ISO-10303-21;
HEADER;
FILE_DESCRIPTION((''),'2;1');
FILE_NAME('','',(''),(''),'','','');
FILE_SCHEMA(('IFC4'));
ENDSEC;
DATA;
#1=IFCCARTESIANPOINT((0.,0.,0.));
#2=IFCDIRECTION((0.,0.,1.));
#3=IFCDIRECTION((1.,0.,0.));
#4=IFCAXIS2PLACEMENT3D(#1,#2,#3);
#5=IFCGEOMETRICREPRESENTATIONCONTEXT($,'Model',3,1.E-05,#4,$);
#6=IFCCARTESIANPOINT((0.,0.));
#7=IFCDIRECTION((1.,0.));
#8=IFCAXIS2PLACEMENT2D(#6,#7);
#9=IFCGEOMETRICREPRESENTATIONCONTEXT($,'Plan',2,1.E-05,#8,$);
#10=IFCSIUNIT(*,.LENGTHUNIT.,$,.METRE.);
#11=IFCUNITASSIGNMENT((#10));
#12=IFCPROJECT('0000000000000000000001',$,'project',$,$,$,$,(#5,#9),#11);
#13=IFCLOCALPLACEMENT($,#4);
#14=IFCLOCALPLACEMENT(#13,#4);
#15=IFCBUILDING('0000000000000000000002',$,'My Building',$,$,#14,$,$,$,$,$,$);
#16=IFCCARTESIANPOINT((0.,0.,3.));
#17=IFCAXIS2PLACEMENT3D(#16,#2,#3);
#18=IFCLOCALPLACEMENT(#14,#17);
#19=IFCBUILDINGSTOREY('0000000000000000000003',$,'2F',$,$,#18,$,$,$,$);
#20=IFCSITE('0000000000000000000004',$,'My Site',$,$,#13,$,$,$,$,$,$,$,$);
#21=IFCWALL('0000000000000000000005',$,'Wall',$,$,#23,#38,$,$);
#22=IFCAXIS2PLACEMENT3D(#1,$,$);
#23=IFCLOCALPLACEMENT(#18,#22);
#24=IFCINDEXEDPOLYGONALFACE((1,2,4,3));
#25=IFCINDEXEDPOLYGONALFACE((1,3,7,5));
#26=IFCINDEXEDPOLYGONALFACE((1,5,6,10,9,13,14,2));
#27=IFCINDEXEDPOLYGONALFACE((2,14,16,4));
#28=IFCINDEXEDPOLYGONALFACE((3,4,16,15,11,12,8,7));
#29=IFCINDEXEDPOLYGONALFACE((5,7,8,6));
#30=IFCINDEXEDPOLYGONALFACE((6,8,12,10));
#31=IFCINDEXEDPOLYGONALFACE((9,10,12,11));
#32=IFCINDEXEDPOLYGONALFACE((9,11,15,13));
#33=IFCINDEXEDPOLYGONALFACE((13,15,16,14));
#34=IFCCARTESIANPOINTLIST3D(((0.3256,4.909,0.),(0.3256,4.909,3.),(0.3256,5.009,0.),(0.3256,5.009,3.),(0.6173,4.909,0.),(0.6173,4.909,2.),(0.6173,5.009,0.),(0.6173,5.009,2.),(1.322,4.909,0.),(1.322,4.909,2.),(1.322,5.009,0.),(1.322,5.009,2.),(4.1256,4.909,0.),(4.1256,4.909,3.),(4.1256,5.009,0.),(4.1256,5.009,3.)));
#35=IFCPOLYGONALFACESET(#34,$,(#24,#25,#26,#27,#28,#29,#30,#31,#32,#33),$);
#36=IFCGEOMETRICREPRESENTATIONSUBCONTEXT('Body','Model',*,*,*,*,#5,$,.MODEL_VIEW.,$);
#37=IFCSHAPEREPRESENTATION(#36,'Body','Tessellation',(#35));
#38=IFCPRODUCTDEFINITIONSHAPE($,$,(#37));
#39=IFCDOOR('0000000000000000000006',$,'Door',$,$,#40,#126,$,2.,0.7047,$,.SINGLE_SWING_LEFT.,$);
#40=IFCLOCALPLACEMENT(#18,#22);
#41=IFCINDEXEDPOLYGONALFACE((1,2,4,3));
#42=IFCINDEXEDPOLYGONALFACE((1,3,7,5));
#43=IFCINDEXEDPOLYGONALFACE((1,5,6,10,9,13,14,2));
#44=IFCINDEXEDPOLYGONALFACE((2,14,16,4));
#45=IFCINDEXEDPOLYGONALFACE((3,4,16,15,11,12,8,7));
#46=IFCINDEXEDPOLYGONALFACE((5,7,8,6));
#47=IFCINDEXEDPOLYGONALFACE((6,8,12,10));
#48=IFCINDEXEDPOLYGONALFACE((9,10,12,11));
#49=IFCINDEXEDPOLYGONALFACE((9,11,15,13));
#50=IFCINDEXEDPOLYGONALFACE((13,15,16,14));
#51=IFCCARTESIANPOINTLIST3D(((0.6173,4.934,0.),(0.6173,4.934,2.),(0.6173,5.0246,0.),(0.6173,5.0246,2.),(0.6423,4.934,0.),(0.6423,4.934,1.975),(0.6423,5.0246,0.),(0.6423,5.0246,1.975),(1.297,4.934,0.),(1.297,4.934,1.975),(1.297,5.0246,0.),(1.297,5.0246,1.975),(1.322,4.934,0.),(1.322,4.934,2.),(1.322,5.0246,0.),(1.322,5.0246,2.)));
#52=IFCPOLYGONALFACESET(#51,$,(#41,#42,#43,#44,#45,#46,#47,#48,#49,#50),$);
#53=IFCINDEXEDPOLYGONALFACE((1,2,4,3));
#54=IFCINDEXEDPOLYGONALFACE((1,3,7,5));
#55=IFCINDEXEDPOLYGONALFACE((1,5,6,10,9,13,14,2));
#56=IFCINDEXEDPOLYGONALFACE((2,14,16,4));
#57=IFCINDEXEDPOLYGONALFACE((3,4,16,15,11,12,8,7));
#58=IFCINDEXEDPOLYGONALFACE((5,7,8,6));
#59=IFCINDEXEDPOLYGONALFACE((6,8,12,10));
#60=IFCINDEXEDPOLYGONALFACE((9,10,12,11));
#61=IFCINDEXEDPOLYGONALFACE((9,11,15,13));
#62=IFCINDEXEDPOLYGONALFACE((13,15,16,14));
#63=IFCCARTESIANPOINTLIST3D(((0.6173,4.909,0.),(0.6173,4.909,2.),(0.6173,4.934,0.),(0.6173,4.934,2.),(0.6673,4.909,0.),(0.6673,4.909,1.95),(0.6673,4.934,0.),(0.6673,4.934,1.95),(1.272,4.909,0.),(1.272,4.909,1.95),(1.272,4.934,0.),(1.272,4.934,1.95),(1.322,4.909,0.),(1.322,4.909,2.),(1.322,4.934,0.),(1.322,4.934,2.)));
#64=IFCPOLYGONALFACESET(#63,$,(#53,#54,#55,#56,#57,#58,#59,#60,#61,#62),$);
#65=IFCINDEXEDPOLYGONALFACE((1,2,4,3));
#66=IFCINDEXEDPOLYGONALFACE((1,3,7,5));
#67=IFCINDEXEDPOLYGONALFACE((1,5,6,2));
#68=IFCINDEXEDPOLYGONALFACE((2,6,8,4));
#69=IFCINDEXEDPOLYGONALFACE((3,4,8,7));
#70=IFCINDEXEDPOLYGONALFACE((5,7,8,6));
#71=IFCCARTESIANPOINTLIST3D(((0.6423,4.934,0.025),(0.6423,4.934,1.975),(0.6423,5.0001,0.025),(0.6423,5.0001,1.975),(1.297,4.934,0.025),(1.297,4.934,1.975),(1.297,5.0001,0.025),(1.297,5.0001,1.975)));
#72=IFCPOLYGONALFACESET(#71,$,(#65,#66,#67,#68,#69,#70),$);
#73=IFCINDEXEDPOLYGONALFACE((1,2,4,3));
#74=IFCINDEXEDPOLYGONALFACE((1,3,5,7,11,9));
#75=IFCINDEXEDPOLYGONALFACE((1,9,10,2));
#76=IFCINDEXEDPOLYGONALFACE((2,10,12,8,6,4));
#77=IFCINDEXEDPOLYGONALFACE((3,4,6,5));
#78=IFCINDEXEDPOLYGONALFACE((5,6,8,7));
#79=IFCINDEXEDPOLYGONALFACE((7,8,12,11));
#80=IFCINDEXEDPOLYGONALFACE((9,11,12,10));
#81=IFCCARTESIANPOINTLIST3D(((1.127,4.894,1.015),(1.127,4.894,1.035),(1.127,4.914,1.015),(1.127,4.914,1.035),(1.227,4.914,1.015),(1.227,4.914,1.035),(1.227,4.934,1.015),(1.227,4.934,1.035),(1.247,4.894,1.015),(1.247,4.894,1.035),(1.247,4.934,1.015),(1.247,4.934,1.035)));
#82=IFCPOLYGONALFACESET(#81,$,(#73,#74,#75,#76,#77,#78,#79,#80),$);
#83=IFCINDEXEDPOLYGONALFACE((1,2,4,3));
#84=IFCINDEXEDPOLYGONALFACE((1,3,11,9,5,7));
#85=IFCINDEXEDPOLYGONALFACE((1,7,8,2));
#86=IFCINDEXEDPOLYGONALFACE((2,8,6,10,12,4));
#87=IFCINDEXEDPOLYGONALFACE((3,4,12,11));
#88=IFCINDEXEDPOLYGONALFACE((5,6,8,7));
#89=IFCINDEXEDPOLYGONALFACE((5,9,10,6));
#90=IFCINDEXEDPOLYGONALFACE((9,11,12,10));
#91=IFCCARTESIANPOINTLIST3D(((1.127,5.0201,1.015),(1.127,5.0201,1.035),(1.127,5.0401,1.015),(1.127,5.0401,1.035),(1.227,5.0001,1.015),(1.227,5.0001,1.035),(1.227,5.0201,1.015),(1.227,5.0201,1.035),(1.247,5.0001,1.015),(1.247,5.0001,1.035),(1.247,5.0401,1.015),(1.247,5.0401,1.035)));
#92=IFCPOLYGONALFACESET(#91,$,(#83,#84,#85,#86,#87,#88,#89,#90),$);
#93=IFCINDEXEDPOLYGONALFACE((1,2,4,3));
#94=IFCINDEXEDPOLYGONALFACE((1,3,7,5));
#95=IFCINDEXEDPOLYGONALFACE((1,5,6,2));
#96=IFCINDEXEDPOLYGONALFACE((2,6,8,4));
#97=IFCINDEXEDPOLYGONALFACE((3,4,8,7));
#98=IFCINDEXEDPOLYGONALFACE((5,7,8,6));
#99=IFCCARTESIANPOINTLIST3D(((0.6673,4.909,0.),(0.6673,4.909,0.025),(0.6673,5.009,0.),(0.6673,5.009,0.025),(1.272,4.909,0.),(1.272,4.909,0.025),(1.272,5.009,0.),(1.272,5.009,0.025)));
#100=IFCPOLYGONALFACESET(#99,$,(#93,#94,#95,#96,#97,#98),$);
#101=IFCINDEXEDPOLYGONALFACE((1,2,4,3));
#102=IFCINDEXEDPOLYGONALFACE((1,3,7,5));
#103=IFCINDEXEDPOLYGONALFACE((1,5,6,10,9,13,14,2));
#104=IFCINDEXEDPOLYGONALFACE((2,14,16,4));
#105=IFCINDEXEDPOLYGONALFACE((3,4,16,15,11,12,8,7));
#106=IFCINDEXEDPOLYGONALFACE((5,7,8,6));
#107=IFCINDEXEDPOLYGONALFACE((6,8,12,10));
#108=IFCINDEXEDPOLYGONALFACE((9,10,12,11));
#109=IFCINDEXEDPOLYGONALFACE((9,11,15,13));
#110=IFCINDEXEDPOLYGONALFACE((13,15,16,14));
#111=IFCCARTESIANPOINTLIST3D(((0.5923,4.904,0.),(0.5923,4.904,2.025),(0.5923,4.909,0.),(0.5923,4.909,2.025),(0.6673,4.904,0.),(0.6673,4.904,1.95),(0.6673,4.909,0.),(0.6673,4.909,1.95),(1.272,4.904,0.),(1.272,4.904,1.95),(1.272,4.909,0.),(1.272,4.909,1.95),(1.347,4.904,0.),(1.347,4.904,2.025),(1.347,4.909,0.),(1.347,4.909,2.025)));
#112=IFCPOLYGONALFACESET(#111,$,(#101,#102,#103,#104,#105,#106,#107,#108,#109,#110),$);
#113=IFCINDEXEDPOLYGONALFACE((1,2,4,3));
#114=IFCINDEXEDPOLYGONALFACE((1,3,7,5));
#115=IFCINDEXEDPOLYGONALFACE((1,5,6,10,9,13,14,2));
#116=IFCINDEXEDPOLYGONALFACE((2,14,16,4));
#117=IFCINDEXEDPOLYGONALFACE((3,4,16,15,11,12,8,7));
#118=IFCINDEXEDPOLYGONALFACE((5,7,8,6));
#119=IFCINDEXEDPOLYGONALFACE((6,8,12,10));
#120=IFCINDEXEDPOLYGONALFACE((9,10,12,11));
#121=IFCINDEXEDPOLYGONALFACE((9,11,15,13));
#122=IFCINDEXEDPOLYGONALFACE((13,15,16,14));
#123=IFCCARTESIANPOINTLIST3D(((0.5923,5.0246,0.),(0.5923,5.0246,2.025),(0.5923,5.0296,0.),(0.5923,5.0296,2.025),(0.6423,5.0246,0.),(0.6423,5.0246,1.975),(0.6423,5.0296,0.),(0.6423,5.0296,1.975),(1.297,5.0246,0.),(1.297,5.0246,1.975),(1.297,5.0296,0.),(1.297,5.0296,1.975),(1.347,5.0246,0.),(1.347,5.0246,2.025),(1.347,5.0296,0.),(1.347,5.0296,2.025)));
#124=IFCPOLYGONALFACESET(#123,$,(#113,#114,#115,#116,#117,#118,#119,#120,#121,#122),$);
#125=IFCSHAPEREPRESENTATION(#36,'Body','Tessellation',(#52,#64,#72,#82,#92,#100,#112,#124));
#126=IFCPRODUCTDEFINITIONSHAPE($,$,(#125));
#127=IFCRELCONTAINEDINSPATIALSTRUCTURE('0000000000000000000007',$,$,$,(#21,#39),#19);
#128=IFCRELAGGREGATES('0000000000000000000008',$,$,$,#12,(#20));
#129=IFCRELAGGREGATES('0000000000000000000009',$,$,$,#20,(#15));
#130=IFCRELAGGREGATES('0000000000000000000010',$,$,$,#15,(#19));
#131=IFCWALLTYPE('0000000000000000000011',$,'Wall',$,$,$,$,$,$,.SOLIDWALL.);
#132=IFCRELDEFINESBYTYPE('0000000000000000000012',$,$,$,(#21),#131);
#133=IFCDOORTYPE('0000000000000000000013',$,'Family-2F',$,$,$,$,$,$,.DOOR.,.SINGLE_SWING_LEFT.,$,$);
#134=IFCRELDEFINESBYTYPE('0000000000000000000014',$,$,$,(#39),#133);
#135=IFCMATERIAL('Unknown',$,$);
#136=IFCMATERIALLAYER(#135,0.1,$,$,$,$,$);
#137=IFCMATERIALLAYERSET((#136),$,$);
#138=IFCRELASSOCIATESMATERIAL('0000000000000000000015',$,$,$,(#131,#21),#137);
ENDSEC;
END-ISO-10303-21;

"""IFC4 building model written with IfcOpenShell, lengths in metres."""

from ifc_helpers import new_model, entity, si_unit, frame, origin_with_axes, origin_2d_with_axis, place, context, subcontext, project, spatial, line, indexed_curve, outline, extrude, shape, source, transform, mapped, material, layer, layer_set, layer_usage, type_object, type_shapes, element, fill, save


model = new_model("IFC4")

# Units and contexts
model_context = context("Model", 3, precision=1e-05, world=origin_with_axes())
plan_context = context("Plan", 2, precision=1e-05, world=origin_2d_with_axis())
body_context_1 = subcontext(model_context, "Body", "Model", "MODEL_VIEW")
body_context_2 = subcontext(plan_context, "Body", "Plan", "PLAN_VIEW")
ifc_project = project(units=[si_unit("LENGTHUNIT", "METRE")], contexts=[model_context, plan_context])

# Site, building, storey
site_placement = place(None, origin_with_axes())
site = spatial("IfcSite", under=ifc_project, at=site_placement, Name="My Site")
building_placement = place(site_placement, origin_with_axes())
building = spatial("IfcBuilding", under=site, at=building_placement, Name="My Building")
storey_placement = place(building_placement, frame((0.0, 0.0, 3.0), z_axis=(0.0, 0.0, 1.0), x_axis=(1.0, 0.0, 0.0)))
storey = spatial("IfcBuildingStorey", under=building, at=storey_placement, Name="2F")

# Shared definitions
ifc_material = material(Name="Unknown")
ifc_layer = layer(ifc_material, 0.1)
ifc_layer_set = layer_set([ifc_layer])
wall_type = type_object("IfcWallType", Name="Wall", PredefinedType="SOLIDWALL", material=ifc_layer_set)

# Wall, opening, door
ifc_layer_usage_1 = layer_usage(ifc_layer_set, "AXIS2", "POSITIVE", 0.0)
wall_1_placement = place(storey_placement, frame((4.1256, 5.009, 0.0), z_axis=(0.0, 0.0, 1.0), x_axis=(-1.0, 0.0, 0.0)))
wall_1 = element("IfcWall", 1, at=wall_1_placement, inside=storey, type_object=wall_type, material=ifc_layer_usage_1, Name="Wall", context=body_context_1, shape_type="SweptSolid", body=[
    extrude(outline(indexed_curve([(0.0, 0.0), (0.0, 0.1), (3.8, 0.1), (3.8, 0.0)], segments=[line(1, 2, 3, 4, 1)])), origin_with_axes(), (0.0, 0.0, 1.0), 3.0),
])
shared_shape_1 = source(origin_with_axes(), body_context_1, "Body", "SweptSolid", [
    extrude(outline(indexed_curve([(0.0, 0.0), (0.7047, 0.0), (0.7047, 2.0), (0.0, 2.0)], segments=[line(1, 2, 3, 4, 1)])), frame((0.0, -0.6, 0.0), z_axis=(0.0, -1.0, 0.0), x_axis=(1.0, 0.0, 0.0)), (0.0, 0.0, -1.0), 1.2),
])
opening_1_placement = place(wall_1_placement, frame((3.5083, 0.1, 0.0), z_axis=(0.0, 0.0, 1.0), x_axis=(-1.0, 0.0, 0.0)))
opening_1 = element("IfcOpeningElement", 2, at=opening_1_placement, cuts=wall_1, PredefinedType="OPENING", context=body_context_1, shape_type="MappedRepresentation", body=[
    mapped(shared_shape_1, transform((0.0, 0.0, 0.0), x_axis=(1.0, 0.0, 0.0), y_axis=(0.0, 1.0, 0.0), z_axis=(0.0, 0.0, 1.0), scale=1.0)),
])
door_type_1 = type_object("IfcDoorType", Name="Family-2F", OperationType="SINGLE_SWING_LEFT", PredefinedType="DOOR")
shared_shape_2 = source(origin_with_axes(), body_context_1, "Body", "SweptSolid", [
    extrude(outline(indexed_curve([(0.0, 0.0), (0.0, 2.0), (0.7047, 2.0), (0.7047, 0.0), (0.6797, 0.0), (0.6797, 1.975), (0.025, 1.975), (0.025, 0.0)], segments=[line(1, 2, 3, 4, 5, 6, 7, 8, 1)])), frame((0.0, 0.025, 0.0), z_axis=(0.0, -1.0, 0.0), x_axis=(1.0, 0.0, 0.0)), (0.0, 0.0, -1.0), 0.0906),
    extrude(outline(indexed_curve([(0.0, 0.0), (0.0, 2.0), (0.7047, 2.0), (0.7047, 0.0), (0.6547, 0.0), (0.6547, 1.95), (0.05, 1.95), (0.05, 0.0)], segments=[line(1, 2, 3, 4, 5, 6, 7, 8, 1)])), frame((0.0, 0.0, 0.0), z_axis=(0.0, -1.0, 0.0), x_axis=(1.0, 0.0, 0.0)), (0.0, 0.0, -1.0), 0.025),
    extrude(outline(indexed_curve([(0.0, 0.0), (0.6547, 0.0), (0.6547, 0.0661), (0.0, 0.0661)], segments=[line(1, 2, 3, 4, 1)])), frame((0.025, 0.025, 0.025), z_axis=(0.0, 0.0, 1.0), x_axis=(1.0, 0.0, 0.0)), (0.0, 0.0, 1.0), 1.95),
    extrude(outline(indexed_curve([(0.0, 0.0), (0.0, -0.04), (-0.12, -0.04), (-0.12, -0.02), (-0.02, -0.02), (-0.02, 0.0)], segments=[line(1, 2, 3, 4, 5, 6, 1)])), frame((0.6297, 0.025, 1.015), z_axis=(0.0, 0.0, 1.0), x_axis=(1.0, 0.0, 0.0)), (0.0, 0.0, 1.0), 0.02),
    extrude(outline(indexed_curve([(0.0, 0.0), (0.0, 0.04), (-0.12, 0.04), (-0.12, 0.02), (-0.02, 0.02), (-0.02, 0.0)], segments=[line(1, 2, 3, 4, 5, 6, 1)])), frame((0.6297, 0.0911, 1.015), z_axis=(0.0, 0.0, 1.0), x_axis=(1.0, 0.0, 0.0)), (0.0, 0.0, 1.0), 0.02),
    extrude(outline(indexed_curve([(0.0, 0.0), (0.6047, 0.0), (0.6047, 0.1), (0.0, 0.1)], segments=[line(1, 2, 3, 4, 1)])), frame((0.05, 0.0, 0.0), z_axis=(0.0, 0.0, 1.0), x_axis=(1.0, 0.0, 0.0)), (0.0, 0.0, 1.0), 0.025),
    extrude(outline(indexed_curve([(0.0, 0.0), (0.0, 2.025), (0.7547, 2.025), (0.7547, 0.0), (0.6797, 0.0), (0.6797, 1.95), (0.075, 1.95), (0.075, 0.0)], segments=[line(1, 2, 3, 4, 5, 6, 7, 8, 1)])), frame((-0.025, -0.005, 0.0), z_axis=(0.0, -1.0, 0.0), x_axis=(1.0, 0.0, 0.0)), (0.0, 0.0, -1.0), 0.005),
    extrude(outline(indexed_curve([(0.0, 0.0), (0.0, 2.025), (0.7547, 2.025), (0.7547, 0.0), (0.7047, 0.0), (0.7047, 1.975), (0.05, 1.975), (0.05, 0.0)], segments=[line(1, 2, 3, 4, 5, 6, 7, 8, 1)])), frame((-0.025, 0.1156, 0.0), z_axis=(0.0, -1.0, 0.0), x_axis=(1.0, 0.0, 0.0)), (0.0, 0.0, -1.0), 0.005),
])
shared_shape_3 = source(origin_with_axes(), body_context_2, "Body", "Curve2D", [
    entity("IfcIndexedPolyCurve", entity("IfcCartesianPointList2D", [[0.0, 0.0], [0.0, 0.1156], [0.025, 0.1156], [0.025, 0.025], [0.05, 0.025], [0.05, 0.0]]), [entity("IfcLineIndex", [1, 2, 3, 4, 5, 6, 1])]),
    entity("IfcIndexedPolyCurve", entity("IfcCartesianPointList2D", [[0.7047, 0.0], [0.7047, 0.1156], [0.6797, 0.1156], [0.6797, 0.025], [0.6547, 0.025], [0.6547, 0.0]]), [entity("IfcLineIndex", [1, 2, 3, 4, 5, 6, 1])]),
    entity("IfcTrimmedCurve", entity("IfcEllipse", entity("IfcAxis2Placement2D", entity("IfcCartesianPoint", [0.0911, 0.1156]), entity("IfcDirection", [1.0, 0.0])), 0.5886, 0.6547), [entity("IfcCartesianPoint", [0.6797, 0.1156])], [entity("IfcCartesianPoint", [0.0911, 0.7702])], True, "CARTESIAN"),
    entity("IfcIndexedPolyCurve", entity("IfcCartesianPointList2D", [[0.025, 0.1156], [0.0911, 0.1156], [0.0911, 0.7702], [0.025, 0.7702]]), [entity("IfcLineIndex", [1, 2, 3, 4, 1])]),
])
type_shapes(door_type_1, [shared_shape_2, shared_shape_3])
door_1_placement = place(opening_1_placement, frame((0.0, 0.0, 0.0), z_axis=(0.0, 0.0, 1.0), x_axis=(1.0, 0.0, 0.0)))
door_1 = element("IfcDoor", 3, at=door_1_placement, inside=storey, type_object=door_type_1, Name="Door", OperationType="SINGLE_SWING_LEFT", OverallHeight=2.0, OverallWidth=0.7047, shapes=[
    shape(body_context_1, "Body", "MappedRepresentation", [mapped(shared_shape_2, transform((0.0, 0.0, 0.0), x_axis=(1.0, 0.0, 0.0), y_axis=(0.0, 1.0, 0.0), z_axis=(0.0, 0.0, 1.0), scale=1.0))]),
    shape(body_context_2, "Body", "MappedRepresentation", [mapped(shared_shape_3, transform((0.0, 0.0, 0.0), x_axis=(1.0, 0.0, 0.0), y_axis=(0.0, 1.0, 0.0), z_axis=(0.0, 0.0, 1.0), scale=1.0))]),
])
fill(opening_1, door_1)

save(model, "model.ifc")
